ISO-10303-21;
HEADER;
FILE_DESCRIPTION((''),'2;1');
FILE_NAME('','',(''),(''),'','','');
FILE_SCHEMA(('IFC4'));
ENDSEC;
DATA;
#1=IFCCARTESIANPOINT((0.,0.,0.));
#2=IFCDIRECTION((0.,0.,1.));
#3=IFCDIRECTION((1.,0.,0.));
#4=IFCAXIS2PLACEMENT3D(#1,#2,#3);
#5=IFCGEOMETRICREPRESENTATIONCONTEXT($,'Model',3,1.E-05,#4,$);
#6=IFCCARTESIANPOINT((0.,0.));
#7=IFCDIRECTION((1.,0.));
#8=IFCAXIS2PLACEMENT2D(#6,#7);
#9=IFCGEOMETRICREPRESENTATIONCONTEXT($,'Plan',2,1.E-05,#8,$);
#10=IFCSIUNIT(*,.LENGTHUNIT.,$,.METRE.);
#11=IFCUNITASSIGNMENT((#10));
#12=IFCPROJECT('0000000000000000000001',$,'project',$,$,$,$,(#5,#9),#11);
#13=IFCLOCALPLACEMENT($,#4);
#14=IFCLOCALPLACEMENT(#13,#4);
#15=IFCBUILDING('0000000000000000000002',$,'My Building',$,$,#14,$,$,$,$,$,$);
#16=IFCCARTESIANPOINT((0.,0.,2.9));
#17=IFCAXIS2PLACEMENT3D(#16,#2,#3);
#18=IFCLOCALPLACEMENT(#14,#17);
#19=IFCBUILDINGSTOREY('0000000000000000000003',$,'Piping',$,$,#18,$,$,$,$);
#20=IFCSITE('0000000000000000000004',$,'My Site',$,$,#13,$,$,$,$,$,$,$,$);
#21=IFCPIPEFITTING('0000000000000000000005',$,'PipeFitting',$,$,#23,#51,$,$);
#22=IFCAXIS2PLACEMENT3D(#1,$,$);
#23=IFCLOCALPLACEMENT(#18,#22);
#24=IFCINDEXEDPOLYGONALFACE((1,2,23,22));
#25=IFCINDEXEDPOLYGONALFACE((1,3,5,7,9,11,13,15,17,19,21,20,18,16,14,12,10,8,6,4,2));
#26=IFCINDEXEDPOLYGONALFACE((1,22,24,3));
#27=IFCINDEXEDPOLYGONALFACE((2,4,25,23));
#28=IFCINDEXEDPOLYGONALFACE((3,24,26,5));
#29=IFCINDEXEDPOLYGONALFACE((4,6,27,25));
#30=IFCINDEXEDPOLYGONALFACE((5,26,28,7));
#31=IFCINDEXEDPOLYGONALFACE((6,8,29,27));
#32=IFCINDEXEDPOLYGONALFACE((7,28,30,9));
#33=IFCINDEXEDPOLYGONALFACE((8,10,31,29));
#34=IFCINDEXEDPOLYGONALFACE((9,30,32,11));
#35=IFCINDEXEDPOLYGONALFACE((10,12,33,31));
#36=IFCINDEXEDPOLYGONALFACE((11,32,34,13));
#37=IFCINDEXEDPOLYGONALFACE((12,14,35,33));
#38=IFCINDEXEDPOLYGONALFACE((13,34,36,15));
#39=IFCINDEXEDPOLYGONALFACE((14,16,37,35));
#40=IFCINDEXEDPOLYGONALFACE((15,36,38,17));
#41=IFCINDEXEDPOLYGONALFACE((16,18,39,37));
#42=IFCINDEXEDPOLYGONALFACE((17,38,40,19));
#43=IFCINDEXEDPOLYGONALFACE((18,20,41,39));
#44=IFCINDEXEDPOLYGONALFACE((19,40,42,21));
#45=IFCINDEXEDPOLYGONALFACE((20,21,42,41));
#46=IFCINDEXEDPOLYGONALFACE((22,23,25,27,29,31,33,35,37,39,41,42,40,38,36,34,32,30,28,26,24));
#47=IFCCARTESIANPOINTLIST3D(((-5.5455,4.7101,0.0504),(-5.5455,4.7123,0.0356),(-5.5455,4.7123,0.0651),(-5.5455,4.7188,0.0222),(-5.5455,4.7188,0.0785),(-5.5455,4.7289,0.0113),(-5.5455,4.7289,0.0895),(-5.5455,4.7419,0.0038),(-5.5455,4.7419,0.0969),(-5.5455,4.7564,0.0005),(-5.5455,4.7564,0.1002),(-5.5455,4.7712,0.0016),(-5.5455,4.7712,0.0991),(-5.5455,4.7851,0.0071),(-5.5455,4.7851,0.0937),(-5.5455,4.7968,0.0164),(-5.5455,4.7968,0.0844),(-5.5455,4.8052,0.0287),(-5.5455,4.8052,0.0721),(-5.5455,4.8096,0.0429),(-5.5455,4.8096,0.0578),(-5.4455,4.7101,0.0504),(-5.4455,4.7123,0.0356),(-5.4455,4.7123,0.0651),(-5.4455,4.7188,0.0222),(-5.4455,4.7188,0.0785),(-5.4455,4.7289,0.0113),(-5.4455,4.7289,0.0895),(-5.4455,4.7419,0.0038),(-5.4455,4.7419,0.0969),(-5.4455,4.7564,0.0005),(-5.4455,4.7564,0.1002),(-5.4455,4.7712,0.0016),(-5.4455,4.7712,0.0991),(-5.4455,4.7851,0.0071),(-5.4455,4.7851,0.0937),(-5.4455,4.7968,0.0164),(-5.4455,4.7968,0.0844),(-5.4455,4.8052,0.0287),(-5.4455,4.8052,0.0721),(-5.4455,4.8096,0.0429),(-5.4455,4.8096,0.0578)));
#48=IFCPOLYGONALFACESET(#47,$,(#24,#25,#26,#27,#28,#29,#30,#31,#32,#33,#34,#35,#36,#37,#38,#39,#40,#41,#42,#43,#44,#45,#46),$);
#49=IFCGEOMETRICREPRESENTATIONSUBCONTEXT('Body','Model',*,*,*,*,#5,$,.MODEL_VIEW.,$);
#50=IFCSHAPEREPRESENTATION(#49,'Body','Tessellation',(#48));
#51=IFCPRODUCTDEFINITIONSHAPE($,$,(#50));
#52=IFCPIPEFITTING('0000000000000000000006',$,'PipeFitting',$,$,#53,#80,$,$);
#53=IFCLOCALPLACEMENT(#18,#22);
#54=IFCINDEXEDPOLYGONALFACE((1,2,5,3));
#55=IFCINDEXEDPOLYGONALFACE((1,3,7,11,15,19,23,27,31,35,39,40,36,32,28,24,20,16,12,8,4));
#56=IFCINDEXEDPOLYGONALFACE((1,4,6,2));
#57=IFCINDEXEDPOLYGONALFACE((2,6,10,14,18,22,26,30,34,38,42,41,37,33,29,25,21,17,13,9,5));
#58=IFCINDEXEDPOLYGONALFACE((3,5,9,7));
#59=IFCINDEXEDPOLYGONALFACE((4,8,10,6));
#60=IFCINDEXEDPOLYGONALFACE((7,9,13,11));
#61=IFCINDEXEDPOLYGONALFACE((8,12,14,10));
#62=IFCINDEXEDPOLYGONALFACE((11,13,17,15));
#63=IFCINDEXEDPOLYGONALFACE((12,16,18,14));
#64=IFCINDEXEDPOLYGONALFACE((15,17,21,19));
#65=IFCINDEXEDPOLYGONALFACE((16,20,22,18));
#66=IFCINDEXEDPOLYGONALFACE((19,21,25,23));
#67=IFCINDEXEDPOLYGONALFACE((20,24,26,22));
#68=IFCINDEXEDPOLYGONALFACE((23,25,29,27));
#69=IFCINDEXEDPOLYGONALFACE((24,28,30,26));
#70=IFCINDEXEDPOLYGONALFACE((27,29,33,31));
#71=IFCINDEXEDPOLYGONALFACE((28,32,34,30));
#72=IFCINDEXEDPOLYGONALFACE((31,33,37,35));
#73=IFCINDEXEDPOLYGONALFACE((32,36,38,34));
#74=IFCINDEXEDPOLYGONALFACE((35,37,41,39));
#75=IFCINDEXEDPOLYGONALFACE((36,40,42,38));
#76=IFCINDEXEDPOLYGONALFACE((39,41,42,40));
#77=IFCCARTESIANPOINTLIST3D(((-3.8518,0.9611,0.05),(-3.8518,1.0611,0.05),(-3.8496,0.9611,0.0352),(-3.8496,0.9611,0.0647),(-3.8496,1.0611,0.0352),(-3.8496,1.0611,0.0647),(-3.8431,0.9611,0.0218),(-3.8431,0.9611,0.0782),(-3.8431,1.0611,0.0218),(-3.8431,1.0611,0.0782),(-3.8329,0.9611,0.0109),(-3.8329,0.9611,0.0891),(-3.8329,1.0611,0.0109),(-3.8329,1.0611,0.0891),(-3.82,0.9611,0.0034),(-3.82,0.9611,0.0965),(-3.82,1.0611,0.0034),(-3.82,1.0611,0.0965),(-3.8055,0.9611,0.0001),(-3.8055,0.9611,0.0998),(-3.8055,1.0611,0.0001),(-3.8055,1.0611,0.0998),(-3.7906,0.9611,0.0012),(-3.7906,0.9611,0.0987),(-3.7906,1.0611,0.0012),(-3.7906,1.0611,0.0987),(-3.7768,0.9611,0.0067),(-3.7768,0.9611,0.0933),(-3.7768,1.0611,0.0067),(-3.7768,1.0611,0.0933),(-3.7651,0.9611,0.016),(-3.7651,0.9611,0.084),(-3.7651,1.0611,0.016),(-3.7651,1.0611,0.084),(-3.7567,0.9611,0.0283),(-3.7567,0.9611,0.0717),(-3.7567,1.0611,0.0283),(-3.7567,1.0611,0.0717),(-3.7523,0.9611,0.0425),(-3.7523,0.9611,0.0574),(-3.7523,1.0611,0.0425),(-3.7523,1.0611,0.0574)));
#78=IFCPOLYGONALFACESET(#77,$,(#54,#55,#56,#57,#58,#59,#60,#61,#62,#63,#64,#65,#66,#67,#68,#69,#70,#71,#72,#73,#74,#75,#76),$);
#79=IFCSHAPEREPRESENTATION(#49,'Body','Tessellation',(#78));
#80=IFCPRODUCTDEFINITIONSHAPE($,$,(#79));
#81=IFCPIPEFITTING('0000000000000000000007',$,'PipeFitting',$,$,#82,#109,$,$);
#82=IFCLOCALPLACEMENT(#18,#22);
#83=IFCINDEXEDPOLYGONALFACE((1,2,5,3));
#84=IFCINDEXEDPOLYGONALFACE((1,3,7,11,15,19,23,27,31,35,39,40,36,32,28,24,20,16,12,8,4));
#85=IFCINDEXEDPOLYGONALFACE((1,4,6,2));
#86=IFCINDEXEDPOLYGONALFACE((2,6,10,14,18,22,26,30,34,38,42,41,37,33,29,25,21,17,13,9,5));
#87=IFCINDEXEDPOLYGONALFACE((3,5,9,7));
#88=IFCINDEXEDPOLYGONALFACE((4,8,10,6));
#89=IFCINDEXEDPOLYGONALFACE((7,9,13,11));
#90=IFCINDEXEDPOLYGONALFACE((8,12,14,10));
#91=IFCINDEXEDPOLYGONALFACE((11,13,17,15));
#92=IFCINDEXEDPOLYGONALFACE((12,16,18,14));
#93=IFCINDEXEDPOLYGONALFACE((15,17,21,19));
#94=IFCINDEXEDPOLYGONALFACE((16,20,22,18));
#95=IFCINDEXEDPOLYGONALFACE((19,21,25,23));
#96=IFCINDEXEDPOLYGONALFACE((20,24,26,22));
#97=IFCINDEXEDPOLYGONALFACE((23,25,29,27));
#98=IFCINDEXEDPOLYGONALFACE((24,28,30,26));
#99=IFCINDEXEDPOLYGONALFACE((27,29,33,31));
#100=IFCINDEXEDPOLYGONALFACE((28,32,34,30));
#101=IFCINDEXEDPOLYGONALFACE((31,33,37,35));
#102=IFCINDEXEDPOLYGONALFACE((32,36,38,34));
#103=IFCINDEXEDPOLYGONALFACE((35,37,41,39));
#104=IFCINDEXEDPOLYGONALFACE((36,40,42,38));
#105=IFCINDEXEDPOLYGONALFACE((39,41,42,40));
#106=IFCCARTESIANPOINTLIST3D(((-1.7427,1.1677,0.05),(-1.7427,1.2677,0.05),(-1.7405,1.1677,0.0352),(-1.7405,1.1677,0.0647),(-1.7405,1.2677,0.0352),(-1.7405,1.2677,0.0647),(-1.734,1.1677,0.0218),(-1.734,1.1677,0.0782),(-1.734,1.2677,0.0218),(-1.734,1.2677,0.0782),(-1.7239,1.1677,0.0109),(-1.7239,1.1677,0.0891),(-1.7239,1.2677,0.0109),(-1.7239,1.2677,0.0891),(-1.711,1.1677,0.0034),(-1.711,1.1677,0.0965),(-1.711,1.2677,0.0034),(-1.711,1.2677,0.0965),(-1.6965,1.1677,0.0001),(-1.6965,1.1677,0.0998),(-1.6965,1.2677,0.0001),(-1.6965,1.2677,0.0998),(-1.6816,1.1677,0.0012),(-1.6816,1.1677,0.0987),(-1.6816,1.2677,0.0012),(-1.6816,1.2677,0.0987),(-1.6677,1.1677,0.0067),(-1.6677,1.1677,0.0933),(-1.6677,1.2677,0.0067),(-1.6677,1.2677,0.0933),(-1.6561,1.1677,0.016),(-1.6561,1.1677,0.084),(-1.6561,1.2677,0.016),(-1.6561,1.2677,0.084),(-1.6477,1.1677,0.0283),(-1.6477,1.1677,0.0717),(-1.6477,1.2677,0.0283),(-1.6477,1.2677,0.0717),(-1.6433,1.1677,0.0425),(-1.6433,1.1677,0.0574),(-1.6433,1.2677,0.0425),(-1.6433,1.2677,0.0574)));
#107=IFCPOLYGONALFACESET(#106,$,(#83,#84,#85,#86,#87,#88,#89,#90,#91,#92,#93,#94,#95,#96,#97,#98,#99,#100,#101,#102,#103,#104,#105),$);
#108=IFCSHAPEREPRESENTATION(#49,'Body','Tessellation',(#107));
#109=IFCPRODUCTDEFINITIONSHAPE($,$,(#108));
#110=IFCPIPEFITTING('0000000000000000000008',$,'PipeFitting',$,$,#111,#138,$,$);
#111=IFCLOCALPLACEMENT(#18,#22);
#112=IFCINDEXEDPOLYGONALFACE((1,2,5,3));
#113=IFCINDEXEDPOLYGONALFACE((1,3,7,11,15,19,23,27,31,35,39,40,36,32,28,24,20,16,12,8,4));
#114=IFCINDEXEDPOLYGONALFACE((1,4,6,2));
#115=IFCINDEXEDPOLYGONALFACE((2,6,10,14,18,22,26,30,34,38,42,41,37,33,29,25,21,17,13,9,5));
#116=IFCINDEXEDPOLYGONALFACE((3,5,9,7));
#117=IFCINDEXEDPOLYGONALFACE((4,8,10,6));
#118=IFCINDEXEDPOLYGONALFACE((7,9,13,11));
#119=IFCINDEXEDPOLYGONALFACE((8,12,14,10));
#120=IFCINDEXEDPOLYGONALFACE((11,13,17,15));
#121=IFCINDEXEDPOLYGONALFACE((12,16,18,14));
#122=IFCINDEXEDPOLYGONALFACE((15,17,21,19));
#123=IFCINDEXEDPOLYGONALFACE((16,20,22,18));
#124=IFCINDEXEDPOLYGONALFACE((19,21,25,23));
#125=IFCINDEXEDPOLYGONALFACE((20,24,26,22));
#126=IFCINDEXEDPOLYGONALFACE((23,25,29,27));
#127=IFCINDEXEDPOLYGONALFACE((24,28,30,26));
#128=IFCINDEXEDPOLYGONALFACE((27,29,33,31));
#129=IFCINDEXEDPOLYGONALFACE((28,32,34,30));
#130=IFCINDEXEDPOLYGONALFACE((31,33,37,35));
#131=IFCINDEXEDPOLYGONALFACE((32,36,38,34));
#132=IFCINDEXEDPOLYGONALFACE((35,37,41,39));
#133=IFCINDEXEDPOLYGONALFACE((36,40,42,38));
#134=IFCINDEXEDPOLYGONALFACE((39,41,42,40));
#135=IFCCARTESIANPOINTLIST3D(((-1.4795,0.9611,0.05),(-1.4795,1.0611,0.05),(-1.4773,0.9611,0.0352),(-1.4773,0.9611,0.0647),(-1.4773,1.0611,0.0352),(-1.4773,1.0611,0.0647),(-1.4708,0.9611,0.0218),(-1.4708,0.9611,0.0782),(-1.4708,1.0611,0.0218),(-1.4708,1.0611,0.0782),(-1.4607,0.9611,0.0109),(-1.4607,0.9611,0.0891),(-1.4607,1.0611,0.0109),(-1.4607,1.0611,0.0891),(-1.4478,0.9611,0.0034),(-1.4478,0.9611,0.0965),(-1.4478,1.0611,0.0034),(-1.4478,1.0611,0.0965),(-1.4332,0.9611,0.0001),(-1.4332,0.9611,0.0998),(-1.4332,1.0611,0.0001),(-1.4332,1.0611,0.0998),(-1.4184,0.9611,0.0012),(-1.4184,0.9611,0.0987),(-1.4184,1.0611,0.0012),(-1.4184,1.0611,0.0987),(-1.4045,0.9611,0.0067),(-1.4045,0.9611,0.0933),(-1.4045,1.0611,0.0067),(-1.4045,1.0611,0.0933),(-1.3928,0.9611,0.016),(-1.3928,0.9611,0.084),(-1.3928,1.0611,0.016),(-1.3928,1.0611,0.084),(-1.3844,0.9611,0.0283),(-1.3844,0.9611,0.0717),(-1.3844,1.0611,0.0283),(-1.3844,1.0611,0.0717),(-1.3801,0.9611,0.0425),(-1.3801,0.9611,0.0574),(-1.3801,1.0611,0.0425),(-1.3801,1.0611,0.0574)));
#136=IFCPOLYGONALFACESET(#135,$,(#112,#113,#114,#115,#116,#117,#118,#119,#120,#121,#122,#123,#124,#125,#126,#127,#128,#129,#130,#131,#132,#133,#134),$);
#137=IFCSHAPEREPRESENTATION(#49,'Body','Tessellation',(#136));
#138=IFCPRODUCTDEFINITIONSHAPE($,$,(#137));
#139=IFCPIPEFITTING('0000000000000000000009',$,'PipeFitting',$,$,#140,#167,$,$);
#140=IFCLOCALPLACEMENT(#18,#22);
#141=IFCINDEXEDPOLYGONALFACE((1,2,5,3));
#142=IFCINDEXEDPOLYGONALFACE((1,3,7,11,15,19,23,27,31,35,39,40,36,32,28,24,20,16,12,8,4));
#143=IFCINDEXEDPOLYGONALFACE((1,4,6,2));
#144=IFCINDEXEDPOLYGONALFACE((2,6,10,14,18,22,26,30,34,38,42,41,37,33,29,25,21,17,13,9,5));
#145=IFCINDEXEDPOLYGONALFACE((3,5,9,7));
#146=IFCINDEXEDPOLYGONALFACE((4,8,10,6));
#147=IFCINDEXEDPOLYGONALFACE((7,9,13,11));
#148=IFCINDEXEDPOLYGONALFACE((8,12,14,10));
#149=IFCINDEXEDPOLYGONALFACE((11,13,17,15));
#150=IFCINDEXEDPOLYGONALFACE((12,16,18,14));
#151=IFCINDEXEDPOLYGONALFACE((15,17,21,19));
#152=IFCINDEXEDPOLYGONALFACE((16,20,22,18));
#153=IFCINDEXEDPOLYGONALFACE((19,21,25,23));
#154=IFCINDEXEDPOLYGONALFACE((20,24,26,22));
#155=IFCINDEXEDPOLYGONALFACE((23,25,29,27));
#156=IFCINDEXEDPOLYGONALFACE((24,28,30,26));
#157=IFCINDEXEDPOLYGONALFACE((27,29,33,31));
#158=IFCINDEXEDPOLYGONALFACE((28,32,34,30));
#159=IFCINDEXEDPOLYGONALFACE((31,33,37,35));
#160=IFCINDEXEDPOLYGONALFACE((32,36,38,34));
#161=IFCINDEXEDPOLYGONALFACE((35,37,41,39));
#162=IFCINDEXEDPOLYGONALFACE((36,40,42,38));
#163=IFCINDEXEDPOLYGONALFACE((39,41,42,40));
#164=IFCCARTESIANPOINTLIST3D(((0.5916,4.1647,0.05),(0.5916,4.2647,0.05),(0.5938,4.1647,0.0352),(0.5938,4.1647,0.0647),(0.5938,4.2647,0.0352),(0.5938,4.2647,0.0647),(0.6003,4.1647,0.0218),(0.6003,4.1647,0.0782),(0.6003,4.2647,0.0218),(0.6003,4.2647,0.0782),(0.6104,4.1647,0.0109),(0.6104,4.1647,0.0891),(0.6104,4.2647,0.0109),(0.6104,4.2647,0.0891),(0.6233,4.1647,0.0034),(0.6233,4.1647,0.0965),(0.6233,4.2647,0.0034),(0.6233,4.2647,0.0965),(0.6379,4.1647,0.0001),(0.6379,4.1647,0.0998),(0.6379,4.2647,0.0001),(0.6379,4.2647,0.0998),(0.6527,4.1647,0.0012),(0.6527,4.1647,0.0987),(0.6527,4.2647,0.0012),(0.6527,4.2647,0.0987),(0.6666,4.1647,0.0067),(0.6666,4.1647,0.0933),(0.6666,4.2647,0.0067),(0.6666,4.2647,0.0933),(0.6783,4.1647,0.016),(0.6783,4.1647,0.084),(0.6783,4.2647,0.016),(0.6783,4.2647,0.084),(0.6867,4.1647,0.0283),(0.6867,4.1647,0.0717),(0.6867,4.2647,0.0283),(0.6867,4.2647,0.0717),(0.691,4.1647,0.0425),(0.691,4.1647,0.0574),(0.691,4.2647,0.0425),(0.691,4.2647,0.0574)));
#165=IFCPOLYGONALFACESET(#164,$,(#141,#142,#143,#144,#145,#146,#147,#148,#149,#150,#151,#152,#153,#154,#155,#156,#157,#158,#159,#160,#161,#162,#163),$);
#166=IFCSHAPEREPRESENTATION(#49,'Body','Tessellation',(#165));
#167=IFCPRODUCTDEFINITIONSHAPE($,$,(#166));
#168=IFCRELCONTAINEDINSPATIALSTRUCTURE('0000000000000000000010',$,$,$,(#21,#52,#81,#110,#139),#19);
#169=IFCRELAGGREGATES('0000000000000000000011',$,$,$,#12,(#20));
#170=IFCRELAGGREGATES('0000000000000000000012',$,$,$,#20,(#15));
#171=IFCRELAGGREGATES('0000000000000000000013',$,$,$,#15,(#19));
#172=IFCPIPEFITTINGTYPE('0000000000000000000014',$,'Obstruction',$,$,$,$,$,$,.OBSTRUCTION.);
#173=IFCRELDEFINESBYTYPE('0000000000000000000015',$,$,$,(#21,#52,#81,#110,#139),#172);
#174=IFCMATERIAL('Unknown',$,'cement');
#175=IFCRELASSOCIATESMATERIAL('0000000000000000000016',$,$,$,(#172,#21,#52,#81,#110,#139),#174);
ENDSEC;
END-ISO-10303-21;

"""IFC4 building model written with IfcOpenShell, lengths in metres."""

from ifc_helpers import new_model, si_unit, frame, origin_with_axes, origin_2d_with_axis, place, context, subcontext, project, spatial, circle, extrude, material, material_profile, profile_set, profile_usage, type_object, element, save


model = new_model("IFC4")

# Units and contexts
model_context = context("Model", 3, precision=1e-05, world=origin_with_axes())
plan_context = context("Plan", 2, precision=1e-05, world=origin_2d_with_axis())
body_context = subcontext(model_context, "Body", "Model", "MODEL_VIEW")
ifc_project = project(units=[si_unit("LENGTHUNIT", "METRE")], contexts=[model_context, plan_context])

# Site, building, storey
site_placement = place(None, origin_with_axes())
site = spatial("IfcSite", under=ifc_project, at=site_placement, Name="My Site")
building_placement = place(site_placement, origin_with_axes())
building = spatial("IfcBuilding", under=site, at=building_placement, Name="My Building")
storey_placement = place(building_placement, frame((0.0, 0.0, 2.9), z_axis=(0.0, 0.0, 1.0), x_axis=(1.0, 0.0, 0.0)))
storey = spatial("IfcBuildingStorey", under=building, at=storey_placement, Name="Piping")

# Shared definitions
ifc_material = material(Name="Unknown", Category="cement")

# Pipe fittings
ifc_material_profile_1 = material_profile(ifc_material, circle(Radius=0.05))
ifc_profile_set_1 = profile_set([ifc_material_profile_1])
ifc_profile_usage_1 = profile_usage(ifc_profile_set_1, cardinal=5)
pipe_fitting_type_1 = type_object("IfcPipeFittingType", Name="Obstruction", PredefinedType="OBSTRUCTION", material=ifc_profile_set_1)
pipe_fitting_1_placement = place(storey_placement, frame((-5.4455, 4.7601, 0.0504), z_axis=(-1.0, 0.0, 0.0), x_axis=(0.0, -1.0, 0.0)))
element("IfcPipeFitting", 1, at=pipe_fitting_1_placement, inside=storey, type_object=pipe_fitting_type_1, material=ifc_profile_usage_1, Name="PipeFitting", context=body_context, shape_type="SweptSolid", body=[
    extrude(circle(Radius=0.05), origin_with_axes(), (0.0, 0.0, 1.0), 0.1),
])
ifc_profile_usage_2 = profile_usage(ifc_profile_set_1, cardinal=5)
pipe_fitting_2_placement = place(storey_placement, frame((-3.8018, 0.9611, 0.05), z_axis=(0.0, 1.0, 0.0), x_axis=(-1.0, 0.0, 0.0)))
element("IfcPipeFitting", 2, at=pipe_fitting_2_placement, inside=storey, type_object=pipe_fitting_type_1, material=ifc_profile_usage_2, Name="PipeFitting", context=body_context, shape_type="SweptSolid", body=[
    extrude(circle(Radius=0.05), origin_with_axes(), (0.0, 0.0, 1.0), 0.1),
])
ifc_profile_usage_3 = profile_usage(ifc_profile_set_1, cardinal=5)
pipe_fitting_3_placement = place(storey_placement, frame((-1.6927, 1.1677, 0.05), z_axis=(0.0, 1.0, 0.0), x_axis=(-1.0, 0.0, 0.0)))
element("IfcPipeFitting", 3, at=pipe_fitting_3_placement, inside=storey, type_object=pipe_fitting_type_1, material=ifc_profile_usage_3, Name="PipeFitting", context=body_context, shape_type="SweptSolid", body=[
    extrude(circle(Radius=0.05), origin_with_axes(), (0.0, 0.0, 1.0), 0.1),
])
ifc_profile_usage_4 = profile_usage(ifc_profile_set_1, cardinal=5)
pipe_fitting_4_placement = place(storey_placement, frame((-1.4295, 0.9611, 0.05), z_axis=(0.0, 1.0, 0.0), x_axis=(-1.0, 0.0, 0.0)))
element("IfcPipeFitting", 4, at=pipe_fitting_4_placement, inside=storey, type_object=pipe_fitting_type_1, material=ifc_profile_usage_4, Name="PipeFitting", context=body_context, shape_type="SweptSolid", body=[
    extrude(circle(Radius=0.05), origin_with_axes(), (0.0, 0.0, 1.0), 0.1),
])
ifc_profile_usage_5 = profile_usage(ifc_profile_set_1, cardinal=5)
pipe_fitting_5_placement = place(storey_placement, frame((0.6416, 4.1647, 0.05), z_axis=(0.0, 1.0, 0.0), x_axis=(-1.0, 0.0, 0.0)))
element("IfcPipeFitting", 5, at=pipe_fitting_5_placement, inside=storey, type_object=pipe_fitting_type_1, material=ifc_profile_usage_5, Name="PipeFitting", context=body_context, shape_type="SweptSolid", body=[
    extrude(circle(Radius=0.05), origin_with_axes(), (0.0, 0.0, 1.0), 0.1),
])

save(model, "model.ifc")
